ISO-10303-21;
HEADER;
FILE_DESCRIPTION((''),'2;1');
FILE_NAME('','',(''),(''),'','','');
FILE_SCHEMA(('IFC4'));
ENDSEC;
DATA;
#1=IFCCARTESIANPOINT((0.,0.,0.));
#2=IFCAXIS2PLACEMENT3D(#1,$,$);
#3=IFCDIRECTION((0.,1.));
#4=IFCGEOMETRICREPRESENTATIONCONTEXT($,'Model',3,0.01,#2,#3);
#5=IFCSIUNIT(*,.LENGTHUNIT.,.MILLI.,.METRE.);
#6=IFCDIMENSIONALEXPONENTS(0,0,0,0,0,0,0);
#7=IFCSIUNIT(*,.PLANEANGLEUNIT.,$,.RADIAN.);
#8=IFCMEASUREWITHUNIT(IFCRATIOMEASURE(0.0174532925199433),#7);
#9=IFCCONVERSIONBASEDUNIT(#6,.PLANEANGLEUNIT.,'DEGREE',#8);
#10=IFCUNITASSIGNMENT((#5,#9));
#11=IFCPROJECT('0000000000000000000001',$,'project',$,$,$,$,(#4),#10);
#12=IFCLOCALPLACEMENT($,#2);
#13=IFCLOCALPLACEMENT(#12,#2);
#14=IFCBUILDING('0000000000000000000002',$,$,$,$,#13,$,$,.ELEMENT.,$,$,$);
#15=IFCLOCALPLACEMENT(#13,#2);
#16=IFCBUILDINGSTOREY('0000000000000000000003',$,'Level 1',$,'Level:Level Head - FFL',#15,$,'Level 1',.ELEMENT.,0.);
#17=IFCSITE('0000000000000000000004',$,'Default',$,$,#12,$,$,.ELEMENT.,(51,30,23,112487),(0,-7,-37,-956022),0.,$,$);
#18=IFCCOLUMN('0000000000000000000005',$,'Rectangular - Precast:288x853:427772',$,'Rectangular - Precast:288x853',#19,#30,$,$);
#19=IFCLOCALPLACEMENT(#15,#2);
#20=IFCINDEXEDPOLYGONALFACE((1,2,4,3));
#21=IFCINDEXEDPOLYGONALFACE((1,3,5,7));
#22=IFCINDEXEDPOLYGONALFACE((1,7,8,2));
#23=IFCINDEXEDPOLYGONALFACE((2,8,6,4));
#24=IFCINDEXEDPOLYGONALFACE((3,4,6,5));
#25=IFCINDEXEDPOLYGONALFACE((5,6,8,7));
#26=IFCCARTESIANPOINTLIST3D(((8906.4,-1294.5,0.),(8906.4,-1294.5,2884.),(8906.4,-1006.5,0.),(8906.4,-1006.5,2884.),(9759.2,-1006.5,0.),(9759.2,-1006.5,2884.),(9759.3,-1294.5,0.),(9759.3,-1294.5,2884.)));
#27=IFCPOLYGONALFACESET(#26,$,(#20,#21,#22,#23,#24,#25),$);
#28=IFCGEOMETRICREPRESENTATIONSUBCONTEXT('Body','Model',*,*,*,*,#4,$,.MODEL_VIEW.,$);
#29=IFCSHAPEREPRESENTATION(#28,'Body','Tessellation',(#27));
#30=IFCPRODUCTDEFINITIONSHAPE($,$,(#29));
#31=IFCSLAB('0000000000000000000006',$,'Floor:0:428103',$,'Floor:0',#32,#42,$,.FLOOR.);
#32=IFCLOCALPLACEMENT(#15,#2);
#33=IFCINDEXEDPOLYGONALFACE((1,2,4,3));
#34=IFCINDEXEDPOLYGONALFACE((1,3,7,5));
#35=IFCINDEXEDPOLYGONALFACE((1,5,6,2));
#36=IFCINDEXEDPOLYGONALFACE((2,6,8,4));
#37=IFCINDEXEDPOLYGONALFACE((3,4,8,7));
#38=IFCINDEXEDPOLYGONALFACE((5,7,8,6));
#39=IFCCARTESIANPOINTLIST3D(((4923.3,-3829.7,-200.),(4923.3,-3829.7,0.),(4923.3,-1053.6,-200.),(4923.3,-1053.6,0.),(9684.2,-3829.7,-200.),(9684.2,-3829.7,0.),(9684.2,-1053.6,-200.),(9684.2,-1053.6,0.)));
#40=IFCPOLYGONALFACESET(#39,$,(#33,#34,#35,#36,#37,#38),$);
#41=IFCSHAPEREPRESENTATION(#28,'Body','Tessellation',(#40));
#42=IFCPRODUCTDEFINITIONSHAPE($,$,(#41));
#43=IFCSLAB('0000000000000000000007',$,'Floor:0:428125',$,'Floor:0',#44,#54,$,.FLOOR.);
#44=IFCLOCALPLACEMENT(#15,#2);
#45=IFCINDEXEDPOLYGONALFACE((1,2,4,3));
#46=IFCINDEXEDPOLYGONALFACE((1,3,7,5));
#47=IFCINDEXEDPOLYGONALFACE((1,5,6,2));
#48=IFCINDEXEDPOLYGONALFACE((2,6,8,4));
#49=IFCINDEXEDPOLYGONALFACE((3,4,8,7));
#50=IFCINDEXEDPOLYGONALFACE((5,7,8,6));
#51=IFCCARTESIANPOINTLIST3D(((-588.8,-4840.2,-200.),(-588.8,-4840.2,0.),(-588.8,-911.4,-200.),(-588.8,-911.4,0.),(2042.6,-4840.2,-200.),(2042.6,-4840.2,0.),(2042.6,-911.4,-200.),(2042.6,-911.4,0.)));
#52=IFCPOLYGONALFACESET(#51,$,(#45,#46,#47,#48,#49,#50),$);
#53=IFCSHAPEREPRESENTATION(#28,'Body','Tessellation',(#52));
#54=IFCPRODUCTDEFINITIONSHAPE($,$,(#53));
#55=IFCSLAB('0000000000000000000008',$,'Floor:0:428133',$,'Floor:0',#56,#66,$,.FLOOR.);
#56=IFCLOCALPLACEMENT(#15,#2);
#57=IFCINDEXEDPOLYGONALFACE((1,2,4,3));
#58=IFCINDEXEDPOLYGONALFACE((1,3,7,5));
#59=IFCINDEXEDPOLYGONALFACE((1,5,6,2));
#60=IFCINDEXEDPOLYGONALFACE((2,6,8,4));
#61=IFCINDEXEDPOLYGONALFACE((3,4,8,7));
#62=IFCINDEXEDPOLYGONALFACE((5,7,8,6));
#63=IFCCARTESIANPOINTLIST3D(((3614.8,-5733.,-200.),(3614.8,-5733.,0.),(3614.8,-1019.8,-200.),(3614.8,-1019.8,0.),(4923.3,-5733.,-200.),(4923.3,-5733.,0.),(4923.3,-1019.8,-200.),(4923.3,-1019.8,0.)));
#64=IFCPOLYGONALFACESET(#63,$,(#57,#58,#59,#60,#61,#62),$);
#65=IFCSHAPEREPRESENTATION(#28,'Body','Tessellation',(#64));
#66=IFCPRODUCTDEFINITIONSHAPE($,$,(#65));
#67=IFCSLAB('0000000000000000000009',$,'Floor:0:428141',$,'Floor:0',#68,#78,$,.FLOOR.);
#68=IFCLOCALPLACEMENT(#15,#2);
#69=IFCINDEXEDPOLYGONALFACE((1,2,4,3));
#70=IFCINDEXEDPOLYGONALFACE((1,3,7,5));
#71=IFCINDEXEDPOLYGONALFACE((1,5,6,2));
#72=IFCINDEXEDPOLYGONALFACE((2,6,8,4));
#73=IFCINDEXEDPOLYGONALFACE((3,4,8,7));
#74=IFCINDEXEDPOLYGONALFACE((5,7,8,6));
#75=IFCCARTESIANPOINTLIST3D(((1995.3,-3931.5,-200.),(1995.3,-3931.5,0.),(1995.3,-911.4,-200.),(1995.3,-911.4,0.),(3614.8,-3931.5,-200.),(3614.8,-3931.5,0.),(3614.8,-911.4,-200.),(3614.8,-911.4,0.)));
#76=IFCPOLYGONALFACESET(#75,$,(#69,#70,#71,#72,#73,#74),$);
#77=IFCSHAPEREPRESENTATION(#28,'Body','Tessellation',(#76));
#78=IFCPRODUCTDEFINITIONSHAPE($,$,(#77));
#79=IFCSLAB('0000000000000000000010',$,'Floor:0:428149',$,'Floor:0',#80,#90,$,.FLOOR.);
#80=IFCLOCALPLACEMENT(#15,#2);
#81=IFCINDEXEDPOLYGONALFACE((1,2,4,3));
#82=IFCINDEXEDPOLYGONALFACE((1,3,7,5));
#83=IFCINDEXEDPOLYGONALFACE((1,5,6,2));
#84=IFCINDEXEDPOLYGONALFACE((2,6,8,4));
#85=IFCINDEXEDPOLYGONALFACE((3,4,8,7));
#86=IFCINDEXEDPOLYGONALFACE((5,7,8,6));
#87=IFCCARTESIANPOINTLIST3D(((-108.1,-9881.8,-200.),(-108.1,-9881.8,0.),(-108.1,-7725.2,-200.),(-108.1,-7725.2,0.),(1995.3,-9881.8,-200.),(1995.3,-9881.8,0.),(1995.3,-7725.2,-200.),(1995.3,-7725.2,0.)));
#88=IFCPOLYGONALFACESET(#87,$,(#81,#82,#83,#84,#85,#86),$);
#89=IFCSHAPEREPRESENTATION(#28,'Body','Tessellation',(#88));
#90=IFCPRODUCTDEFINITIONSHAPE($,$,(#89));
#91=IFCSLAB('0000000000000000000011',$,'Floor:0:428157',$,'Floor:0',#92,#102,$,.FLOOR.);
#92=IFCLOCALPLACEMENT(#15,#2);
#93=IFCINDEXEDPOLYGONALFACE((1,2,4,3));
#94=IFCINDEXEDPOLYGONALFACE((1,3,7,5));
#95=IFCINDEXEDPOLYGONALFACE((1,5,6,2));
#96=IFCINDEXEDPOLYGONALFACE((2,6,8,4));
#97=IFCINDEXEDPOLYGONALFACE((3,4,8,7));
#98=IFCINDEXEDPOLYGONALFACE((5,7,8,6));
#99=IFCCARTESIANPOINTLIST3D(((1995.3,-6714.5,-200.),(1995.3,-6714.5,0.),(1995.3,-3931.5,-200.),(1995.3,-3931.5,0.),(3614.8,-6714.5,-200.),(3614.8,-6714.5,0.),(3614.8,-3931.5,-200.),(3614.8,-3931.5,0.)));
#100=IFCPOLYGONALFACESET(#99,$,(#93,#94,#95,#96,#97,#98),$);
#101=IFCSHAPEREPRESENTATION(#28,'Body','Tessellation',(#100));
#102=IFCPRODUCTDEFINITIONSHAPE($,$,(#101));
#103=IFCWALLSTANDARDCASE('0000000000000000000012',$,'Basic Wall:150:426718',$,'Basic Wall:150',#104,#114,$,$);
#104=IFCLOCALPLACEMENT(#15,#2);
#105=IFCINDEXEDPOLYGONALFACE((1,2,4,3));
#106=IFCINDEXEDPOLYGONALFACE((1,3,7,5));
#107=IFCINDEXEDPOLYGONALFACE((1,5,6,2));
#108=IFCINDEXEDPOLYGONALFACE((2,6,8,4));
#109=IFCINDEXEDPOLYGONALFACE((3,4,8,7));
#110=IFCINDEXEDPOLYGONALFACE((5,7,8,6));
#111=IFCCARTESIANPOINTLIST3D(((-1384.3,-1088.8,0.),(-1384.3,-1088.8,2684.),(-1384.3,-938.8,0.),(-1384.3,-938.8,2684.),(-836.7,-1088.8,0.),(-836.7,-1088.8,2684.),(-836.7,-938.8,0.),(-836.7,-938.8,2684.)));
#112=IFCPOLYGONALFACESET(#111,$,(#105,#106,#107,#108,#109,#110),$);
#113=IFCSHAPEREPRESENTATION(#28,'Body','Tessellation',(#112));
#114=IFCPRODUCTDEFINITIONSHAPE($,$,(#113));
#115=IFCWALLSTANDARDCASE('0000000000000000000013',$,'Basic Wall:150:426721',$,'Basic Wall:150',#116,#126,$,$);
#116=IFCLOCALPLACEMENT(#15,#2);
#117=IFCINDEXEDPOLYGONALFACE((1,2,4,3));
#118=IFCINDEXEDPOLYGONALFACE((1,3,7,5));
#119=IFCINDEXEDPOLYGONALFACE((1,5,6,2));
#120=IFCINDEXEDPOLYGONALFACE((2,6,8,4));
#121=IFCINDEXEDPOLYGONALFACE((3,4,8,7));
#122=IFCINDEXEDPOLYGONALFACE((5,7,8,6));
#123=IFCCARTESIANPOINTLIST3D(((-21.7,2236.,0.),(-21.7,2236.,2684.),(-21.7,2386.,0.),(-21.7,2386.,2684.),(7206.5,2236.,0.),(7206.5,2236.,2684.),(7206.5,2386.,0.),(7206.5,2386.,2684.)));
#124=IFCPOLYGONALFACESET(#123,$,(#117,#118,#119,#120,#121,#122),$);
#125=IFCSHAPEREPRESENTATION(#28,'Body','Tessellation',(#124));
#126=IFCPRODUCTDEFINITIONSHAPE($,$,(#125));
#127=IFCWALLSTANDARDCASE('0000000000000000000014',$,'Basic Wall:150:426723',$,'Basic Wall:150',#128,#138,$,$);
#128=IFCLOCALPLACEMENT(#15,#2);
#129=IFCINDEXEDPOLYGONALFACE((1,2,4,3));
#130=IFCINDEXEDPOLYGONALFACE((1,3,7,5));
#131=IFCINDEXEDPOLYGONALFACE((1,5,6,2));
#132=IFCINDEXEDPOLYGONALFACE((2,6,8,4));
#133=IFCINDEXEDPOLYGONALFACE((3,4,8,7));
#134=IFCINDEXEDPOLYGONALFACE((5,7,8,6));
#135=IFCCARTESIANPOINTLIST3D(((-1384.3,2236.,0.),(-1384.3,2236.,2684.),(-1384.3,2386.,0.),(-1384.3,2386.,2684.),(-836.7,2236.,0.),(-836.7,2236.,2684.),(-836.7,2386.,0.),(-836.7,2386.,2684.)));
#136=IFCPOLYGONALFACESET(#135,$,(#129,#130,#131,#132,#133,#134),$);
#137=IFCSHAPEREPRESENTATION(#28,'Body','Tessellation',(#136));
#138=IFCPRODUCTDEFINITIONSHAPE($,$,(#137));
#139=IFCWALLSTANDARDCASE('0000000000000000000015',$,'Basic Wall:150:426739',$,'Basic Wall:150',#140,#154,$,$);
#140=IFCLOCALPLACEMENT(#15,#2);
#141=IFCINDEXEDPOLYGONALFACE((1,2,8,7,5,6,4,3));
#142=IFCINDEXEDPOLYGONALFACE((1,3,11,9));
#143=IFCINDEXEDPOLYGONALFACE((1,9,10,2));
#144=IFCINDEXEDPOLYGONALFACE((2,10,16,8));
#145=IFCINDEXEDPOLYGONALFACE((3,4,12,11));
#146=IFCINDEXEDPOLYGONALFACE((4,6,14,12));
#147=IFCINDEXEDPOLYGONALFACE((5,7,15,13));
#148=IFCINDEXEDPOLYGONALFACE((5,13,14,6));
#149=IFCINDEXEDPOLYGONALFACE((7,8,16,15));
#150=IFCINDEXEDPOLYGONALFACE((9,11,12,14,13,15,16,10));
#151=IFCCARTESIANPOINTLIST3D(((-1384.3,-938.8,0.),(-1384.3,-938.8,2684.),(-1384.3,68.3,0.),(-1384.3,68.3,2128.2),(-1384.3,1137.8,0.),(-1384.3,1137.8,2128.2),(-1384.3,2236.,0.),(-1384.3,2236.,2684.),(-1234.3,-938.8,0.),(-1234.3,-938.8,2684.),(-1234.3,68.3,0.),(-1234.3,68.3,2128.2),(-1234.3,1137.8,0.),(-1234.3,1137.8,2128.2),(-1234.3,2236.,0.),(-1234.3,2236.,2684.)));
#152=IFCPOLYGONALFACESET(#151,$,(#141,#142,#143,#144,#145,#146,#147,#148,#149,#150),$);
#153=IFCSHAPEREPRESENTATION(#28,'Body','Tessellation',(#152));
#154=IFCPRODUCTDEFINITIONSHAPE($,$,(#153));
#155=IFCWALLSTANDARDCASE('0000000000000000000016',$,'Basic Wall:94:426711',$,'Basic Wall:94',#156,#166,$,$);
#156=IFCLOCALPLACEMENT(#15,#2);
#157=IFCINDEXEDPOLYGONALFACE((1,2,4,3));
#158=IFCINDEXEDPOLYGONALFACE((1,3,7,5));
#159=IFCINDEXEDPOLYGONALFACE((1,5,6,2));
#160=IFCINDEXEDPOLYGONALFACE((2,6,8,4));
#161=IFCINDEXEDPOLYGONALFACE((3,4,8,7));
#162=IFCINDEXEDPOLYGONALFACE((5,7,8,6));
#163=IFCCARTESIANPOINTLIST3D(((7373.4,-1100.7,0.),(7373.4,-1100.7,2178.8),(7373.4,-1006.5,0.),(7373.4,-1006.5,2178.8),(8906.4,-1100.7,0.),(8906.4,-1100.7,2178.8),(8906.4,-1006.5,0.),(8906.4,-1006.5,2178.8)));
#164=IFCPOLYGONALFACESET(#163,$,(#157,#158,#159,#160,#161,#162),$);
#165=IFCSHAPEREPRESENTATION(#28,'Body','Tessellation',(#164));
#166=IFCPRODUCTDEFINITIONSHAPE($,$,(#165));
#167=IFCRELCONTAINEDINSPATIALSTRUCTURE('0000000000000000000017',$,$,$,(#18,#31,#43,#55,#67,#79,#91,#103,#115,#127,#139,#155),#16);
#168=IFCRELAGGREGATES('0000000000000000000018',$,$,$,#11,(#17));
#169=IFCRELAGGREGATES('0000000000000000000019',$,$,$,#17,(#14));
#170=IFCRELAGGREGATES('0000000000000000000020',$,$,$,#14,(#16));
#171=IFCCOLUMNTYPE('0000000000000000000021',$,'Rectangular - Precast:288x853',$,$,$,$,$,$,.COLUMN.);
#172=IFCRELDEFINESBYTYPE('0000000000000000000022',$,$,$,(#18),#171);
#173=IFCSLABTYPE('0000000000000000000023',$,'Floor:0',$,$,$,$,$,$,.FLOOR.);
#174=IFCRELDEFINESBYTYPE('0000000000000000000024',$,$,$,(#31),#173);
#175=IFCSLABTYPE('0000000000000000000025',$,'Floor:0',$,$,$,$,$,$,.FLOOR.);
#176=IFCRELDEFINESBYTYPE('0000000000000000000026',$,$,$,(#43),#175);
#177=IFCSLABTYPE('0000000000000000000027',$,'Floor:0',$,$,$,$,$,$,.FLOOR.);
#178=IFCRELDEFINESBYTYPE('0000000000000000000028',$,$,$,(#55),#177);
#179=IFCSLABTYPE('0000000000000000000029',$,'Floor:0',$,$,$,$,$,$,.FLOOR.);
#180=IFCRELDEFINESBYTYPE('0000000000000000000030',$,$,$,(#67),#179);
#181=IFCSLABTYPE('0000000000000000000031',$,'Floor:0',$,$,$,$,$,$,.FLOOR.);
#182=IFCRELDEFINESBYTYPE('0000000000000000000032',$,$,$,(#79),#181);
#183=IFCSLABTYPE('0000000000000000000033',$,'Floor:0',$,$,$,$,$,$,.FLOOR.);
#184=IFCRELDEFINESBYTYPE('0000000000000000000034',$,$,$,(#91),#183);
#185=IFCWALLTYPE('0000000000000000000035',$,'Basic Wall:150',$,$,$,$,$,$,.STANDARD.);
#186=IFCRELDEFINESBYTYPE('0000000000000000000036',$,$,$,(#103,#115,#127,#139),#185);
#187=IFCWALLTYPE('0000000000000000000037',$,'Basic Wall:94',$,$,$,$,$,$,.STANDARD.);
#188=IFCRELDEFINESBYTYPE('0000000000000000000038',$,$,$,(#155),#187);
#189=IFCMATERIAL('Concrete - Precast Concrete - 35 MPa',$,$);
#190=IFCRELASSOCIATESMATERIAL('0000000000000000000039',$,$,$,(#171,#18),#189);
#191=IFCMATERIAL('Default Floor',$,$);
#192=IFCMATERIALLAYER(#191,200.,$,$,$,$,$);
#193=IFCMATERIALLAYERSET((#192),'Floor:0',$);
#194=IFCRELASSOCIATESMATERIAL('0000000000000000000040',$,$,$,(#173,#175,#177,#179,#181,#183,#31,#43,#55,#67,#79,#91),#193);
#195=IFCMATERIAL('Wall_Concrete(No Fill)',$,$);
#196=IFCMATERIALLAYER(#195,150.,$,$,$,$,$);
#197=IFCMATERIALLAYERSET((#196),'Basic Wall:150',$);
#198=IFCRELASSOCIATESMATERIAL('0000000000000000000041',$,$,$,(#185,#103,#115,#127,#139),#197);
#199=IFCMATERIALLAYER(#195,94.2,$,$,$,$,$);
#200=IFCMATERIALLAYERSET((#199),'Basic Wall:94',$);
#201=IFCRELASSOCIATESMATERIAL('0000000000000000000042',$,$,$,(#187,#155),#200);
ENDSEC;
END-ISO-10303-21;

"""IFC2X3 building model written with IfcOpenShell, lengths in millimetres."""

from ifc_helpers import new_model, entity, si_unit, converted_unit, direction, frame, frame_2d, origin, origin_2d_with_axis, place, context, subcontext, project, spatial, rectangle, extrude, source, transform, mapped, material, layer, layer_set, layer_usage, type_object, type_shapes, element, save


model = new_model("IFC2X3")

# Units and contexts
model_context = context("Model", 3, precision=0.01, world=origin(), true_north=direction((0.0, 1.0)))
body_context = subcontext(model_context, "Body", "Model", "MODEL_VIEW")
ifc_project = project(units=[si_unit("LENGTHUNIT", "METRE", prefix="MILLI"), converted_unit("PLANEANGLEUNIT", "DEGREE", entity("IfcRatioMeasure", 0.0174532925199433), si_unit("PLANEANGLEUNIT", "RADIAN"), dimensions=[0, 0, 0, 0, 0, 0, 0])], contexts=[model_context])

# Site, building, storey
site_placement = place(None, origin())
site = spatial("IfcSite", under=ifc_project, at=site_placement, Name="Default", CompositionType="ELEMENT", RefLatitude=(51, 30, 23, 112487), RefLongitude=(0, -7, -37, -956022), RefElevation=0.0)
building_placement = place(site_placement, origin())
building = spatial("IfcBuilding", under=site, at=building_placement, CompositionType="ELEMENT")
storey_placement = place(building_placement, origin())
storey = spatial("IfcBuildingStorey", under=building, at=storey_placement, Name="Level 1", ObjectType="Level:Level Head - FFL", LongName="Level 1", CompositionType="ELEMENT", Elevation=0.0)

# Column
ifc_material_1 = material(Name="Concrete - Precast Concrete - 35 MPa")
column_type = type_object("IfcColumnType", Name="Rectangular - Precast:288x853", PredefinedType="COLUMN", material=ifc_material_1)
shared_shape_1 = source(origin(), body_context, "Body", "SweptSolid", [
    extrude(rectangle(XDim=852.8, YDim=288.0, at=frame_2d((0.0, 0.0), x_axis=(1.0, 0.0))), frame((0.0, 0.0, 0.0), z_axis=(0.0, 0.0, 1.0), x_axis=(0.0, -1.0, 0.0)), (0.0, 0.0, 1.0), 2884.0),
])
type_shapes(column_type, [shared_shape_1])
column_placement = place(storey_placement, frame((9332.8, -1150.5, 0.0), z_axis=(0.0, 0.0, 1.0), x_axis=(-0.000004, 1.0, 0.0)))
element("IfcColumn", 1, at=column_placement, inside=storey, type_object=column_type, material=ifc_material_1, Name="Rectangular - Precast:288x853:427772", ObjectType="Rectangular - Precast:288x853", context=body_context, shape_type="MappedRepresentation", body=[
    mapped(shared_shape_1, transform((0.0, 0.0, 0.0), scale=1.0)),
])

# Slabs
ifc_material_2 = material(Name="Default Floor")
ifc_layer_1 = layer(ifc_material_2, 200.0)
ifc_layer_set_1 = layer_set([ifc_layer_1], Name="Floor:0")
ifc_layer_usage_1 = layer_usage(ifc_layer_set_1, "AXIS3", "POSITIVE", 0.0)
slab_type_1 = type_object("IfcSlabType", Name="Floor:0", PredefinedType="FLOOR", material=ifc_layer_set_1)
slab_1_placement = place(storey_placement, origin())
element("IfcSlab", 2, at=slab_1_placement, inside=storey, type_object=slab_type_1, material=ifc_layer_usage_1, Name="Floor:0:428103", ObjectType="Floor:0", PredefinedType="FLOOR", context=body_context, shape_type="SweptSolid", body=[
    extrude(rectangle(XDim=2776.1, YDim=4761.0, at=frame_2d((0.0, 0.0), x_axis=(1.0, 0.0))), frame((7303.8, -2441.6, 0.0), z_axis=(0.0, 0.0, -1.0), x_axis=(0.0, 1.0, 0.0)), (0.0, 0.0, 1.0), 200.0),
])
ifc_layer_usage_2 = layer_usage(ifc_layer_set_1, "AXIS3", "POSITIVE", 0.0)
slab_type_2 = type_object("IfcSlabType", Name="Floor:0", PredefinedType="FLOOR", material=ifc_layer_set_1)
slab_2_placement = place(storey_placement, origin())
element("IfcSlab", 3, at=slab_2_placement, inside=storey, type_object=slab_type_2, material=ifc_layer_usage_2, Name="Floor:0:428125", ObjectType="Floor:0", PredefinedType="FLOOR", context=body_context, shape_type="SweptSolid", body=[
    extrude(rectangle(XDim=3928.8, YDim=2631.4, at=frame_2d((0.0, 0.0), x_axis=(1.0, 0.0))), frame((726.9, -2875.8, 0.0), z_axis=(0.0, 0.0, -1.0), x_axis=(0.0, 1.0, 0.0)), (0.0, 0.0, 1.0), 200.0),
])
ifc_layer_usage_3 = layer_usage(ifc_layer_set_1, "AXIS3", "POSITIVE", 0.0)
slab_type_3 = type_object("IfcSlabType", Name="Floor:0", PredefinedType="FLOOR", material=ifc_layer_set_1)
slab_3_placement = place(storey_placement, origin())
element("IfcSlab", 4, at=slab_3_placement, inside=storey, type_object=slab_type_3, material=ifc_layer_usage_3, Name="Floor:0:428133", ObjectType="Floor:0", PredefinedType="FLOOR", context=body_context, shape_type="SweptSolid", body=[
    extrude(rectangle(XDim=4713.3, YDim=1308.5, at=origin_2d_with_axis()), frame((4269.0, -3376.4, 0.0), z_axis=(0.0, 0.0, -1.0), x_axis=(0.0, 1.0, 0.0)), (0.0, 0.0, 1.0), 200.0),
])
ifc_layer_usage_4 = layer_usage(ifc_layer_set_1, "AXIS3", "POSITIVE", 0.0)
slab_type_4 = type_object("IfcSlabType", Name="Floor:0", PredefinedType="FLOOR", material=ifc_layer_set_1)
slab_4_placement = place(storey_placement, origin())
element("IfcSlab", 5, at=slab_4_placement, inside=storey, type_object=slab_type_4, material=ifc_layer_usage_4, Name="Floor:0:428141", ObjectType="Floor:0", PredefinedType="FLOOR", context=body_context, shape_type="SweptSolid", body=[
    extrude(rectangle(XDim=3020.1, YDim=1619.5, at=frame_2d((0.0, 0.0), x_axis=(1.0, 0.0))), frame((2805.1, -2421.5, 0.0), z_axis=(0.0, 0.0, -1.0), x_axis=(0.0, 1.0, 0.0)), (0.0, 0.0, 1.0), 200.0),
])
ifc_layer_usage_5 = layer_usage(ifc_layer_set_1, "AXIS3", "POSITIVE", 0.0)
slab_type_5 = type_object("IfcSlabType", Name="Floor:0", PredefinedType="FLOOR", material=ifc_layer_set_1)
slab_5_placement = place(storey_placement, origin())
element("IfcSlab", 6, at=slab_5_placement, inside=storey, type_object=slab_type_5, material=ifc_layer_usage_5, Name="Floor:0:428149", ObjectType="Floor:0", PredefinedType="FLOOR", context=body_context, shape_type="SweptSolid", body=[
    extrude(rectangle(XDim=2156.7, YDim=2103.4, at=origin_2d_with_axis()), frame((943.6, -8803.5, 0.0), z_axis=(0.0, 0.0, -1.0), x_axis=(0.0, 1.0, 0.0)), (0.0, 0.0, 1.0), 200.0),
])
ifc_layer_usage_6 = layer_usage(ifc_layer_set_1, "AXIS3", "POSITIVE", 0.0)
slab_type_6 = type_object("IfcSlabType", Name="Floor:0", PredefinedType="FLOOR", material=ifc_layer_set_1)
slab_6_placement = place(storey_placement, origin())
element("IfcSlab", 7, at=slab_6_placement, inside=storey, type_object=slab_type_6, material=ifc_layer_usage_6, Name="Floor:0:428157", ObjectType="Floor:0", PredefinedType="FLOOR", context=body_context, shape_type="SweptSolid", body=[
    extrude(rectangle(XDim=2783.0, YDim=1619.5, at=frame_2d((0.0, 0.0), x_axis=(1.0, 0.0))), frame((2805.1, -5323.0, 0.0), z_axis=(0.0, 0.0, -1.0), x_axis=(0.0, 1.0, 0.0)), (0.0, 0.0, 1.0), 200.0),
])

# Walls
ifc_material_3 = material(Name="Wall_Concrete(No Fill)")
ifc_layer_2 = layer(ifc_material_3, 150.0)
ifc_layer_set_2 = layer_set([ifc_layer_2], Name="Basic Wall:150")
ifc_layer_usage_7 = layer_usage(ifc_layer_set_2, "AXIS2", "NEGATIVE", 75.0)
wall_type_1 = type_object("IfcWallType", Name="Basic Wall:150", PredefinedType="STANDARD", material=ifc_layer_set_2)
wall_1_placement = place(storey_placement, frame((-1384.3, -1013.8, 0.0)))
element("IfcWallStandardCase", 8, at=wall_1_placement, inside=storey, type_object=wall_type_1, material=ifc_layer_usage_7, Name="Basic Wall:150:426718", ObjectType="Basic Wall:150", context=body_context, shape_type="SweptSolid", body=[
    extrude(rectangle(XDim=547.6, YDim=150.0, at=frame_2d((273.8, 0.0), x_axis=(-1.0, 0.0))), origin(), (0.0, 0.0, 1.0), 2684.0),
])
ifc_layer_usage_8 = layer_usage(ifc_layer_set_2, "AXIS2", "NEGATIVE", 75.0)
wall_2_placement = place(storey_placement, frame((-21.7, 2311.0, 0.0)))
element("IfcWallStandardCase", 9, at=wall_2_placement, inside=storey, type_object=wall_type_1, material=ifc_layer_usage_8, Name="Basic Wall:150:426721", ObjectType="Basic Wall:150", context=body_context, shape_type="SweptSolid", body=[
    extrude(rectangle(XDim=7228.2, YDim=150.0, at=frame_2d((3614.1, 0.0), x_axis=(-1.0, 0.0))), origin(), (0.0, 0.0, 1.0), 2684.0),
])
ifc_layer_usage_9 = layer_usage(ifc_layer_set_2, "AXIS2", "NEGATIVE", 75.0)
wall_3_placement = place(storey_placement, frame((-1384.3, 2311.0, 0.0)))
element("IfcWallStandardCase", 10, at=wall_3_placement, inside=storey, type_object=wall_type_1, material=ifc_layer_usage_9, Name="Basic Wall:150:426723", ObjectType="Basic Wall:150", context=body_context, shape_type="SweptSolid", body=[
    extrude(rectangle(XDim=547.6, YDim=150.0, at=frame_2d((273.8, 0.0), x_axis=(-1.0, 0.0))), origin(), (0.0, 0.0, 1.0), 2684.0),
])

# Walls, openings
ifc_layer_usage_10 = layer_usage(ifc_layer_set_2, "AXIS2", "NEGATIVE", 75.0)
wall_4_placement = place(storey_placement, frame((-1309.3, -938.8, 0.0), z_axis=(0.0, 0.0, 1.0), x_axis=(0.0, 1.0, 0.0)))
wall_4 = element("IfcWallStandardCase", 11, at=wall_4_placement, inside=storey, type_object=wall_type_1, material=ifc_layer_usage_10, Name="Basic Wall:150:426739", ObjectType="Basic Wall:150", context=body_context, shape_type="SweptSolid", body=[
    extrude(rectangle(XDim=3174.8, YDim=150.0, at=frame_2d((1587.4, 0.0), x_axis=(-1.0, 0.0))), origin(), (0.0, 0.0, 1.0), 2684.0),
])
opening_1_placement = place(wall_4_placement, origin())
element("IfcOpeningElement", 12, at=opening_1_placement, cuts=wall_4, ObjectType="Opening", context=body_context, shape_type="SweptSolid", body=[
    extrude(rectangle(XDim=2128.2, YDim=1069.5, at=origin_2d_with_axis()), frame((1541.8, -75.0, 1064.1), z_axis=(0.0, 1.0, 0.0), x_axis=(0.0, 0.0, -1.0)), (0.0, 0.0, 1.0), 150.0),
])
ifc_layer_3 = layer(ifc_material_3, 94.2)
ifc_layer_set_3 = layer_set([ifc_layer_3], Name="Basic Wall:94")
ifc_layer_usage_11 = layer_usage(ifc_layer_set_3, "AXIS2", "NEGATIVE", 47.1)
wall_type_2 = type_object("IfcWallType", Name="Basic Wall:94", PredefinedType="STANDARD", material=ifc_layer_set_3)
wall_5_placement = place(storey_placement, frame((7373.4, -1053.6, 0.0)))
wall_5 = element("IfcWallStandardCase", 13, at=wall_5_placement, inside=storey, type_object=wall_type_2, material=ifc_layer_usage_11, Name="Basic Wall:94:426711", ObjectType="Basic Wall:94", context=body_context, shape_type="SweptSolid", body=[
    extrude(rectangle(XDim=1533.0, YDim=94.2, at=frame_2d((766.5, 0.0), x_axis=(-1.0, 0.0))), origin(), (0.0, 0.0, 1.0), 2178.8),
])
opening_2_placement = place(wall_5_placement, origin())
element("IfcOpeningElement", 14, at=opening_2_placement, cuts=wall_5, ObjectType="Opening", context=body_context, shape_type="SweptSolid", body=[
    extrude(rectangle(XDim=705.2, YDim=1533.0, at=frame_2d((0.0, 0.0), x_axis=(1.0, 0.0))), frame((766.5, -47.1, 2531.4), z_axis=(0.0, 1.0, 0.0), x_axis=(0.0, 0.0, -1.0)), (0.0, 0.0, 1.0), 94.2),
])

save(model, "model.ifc")
